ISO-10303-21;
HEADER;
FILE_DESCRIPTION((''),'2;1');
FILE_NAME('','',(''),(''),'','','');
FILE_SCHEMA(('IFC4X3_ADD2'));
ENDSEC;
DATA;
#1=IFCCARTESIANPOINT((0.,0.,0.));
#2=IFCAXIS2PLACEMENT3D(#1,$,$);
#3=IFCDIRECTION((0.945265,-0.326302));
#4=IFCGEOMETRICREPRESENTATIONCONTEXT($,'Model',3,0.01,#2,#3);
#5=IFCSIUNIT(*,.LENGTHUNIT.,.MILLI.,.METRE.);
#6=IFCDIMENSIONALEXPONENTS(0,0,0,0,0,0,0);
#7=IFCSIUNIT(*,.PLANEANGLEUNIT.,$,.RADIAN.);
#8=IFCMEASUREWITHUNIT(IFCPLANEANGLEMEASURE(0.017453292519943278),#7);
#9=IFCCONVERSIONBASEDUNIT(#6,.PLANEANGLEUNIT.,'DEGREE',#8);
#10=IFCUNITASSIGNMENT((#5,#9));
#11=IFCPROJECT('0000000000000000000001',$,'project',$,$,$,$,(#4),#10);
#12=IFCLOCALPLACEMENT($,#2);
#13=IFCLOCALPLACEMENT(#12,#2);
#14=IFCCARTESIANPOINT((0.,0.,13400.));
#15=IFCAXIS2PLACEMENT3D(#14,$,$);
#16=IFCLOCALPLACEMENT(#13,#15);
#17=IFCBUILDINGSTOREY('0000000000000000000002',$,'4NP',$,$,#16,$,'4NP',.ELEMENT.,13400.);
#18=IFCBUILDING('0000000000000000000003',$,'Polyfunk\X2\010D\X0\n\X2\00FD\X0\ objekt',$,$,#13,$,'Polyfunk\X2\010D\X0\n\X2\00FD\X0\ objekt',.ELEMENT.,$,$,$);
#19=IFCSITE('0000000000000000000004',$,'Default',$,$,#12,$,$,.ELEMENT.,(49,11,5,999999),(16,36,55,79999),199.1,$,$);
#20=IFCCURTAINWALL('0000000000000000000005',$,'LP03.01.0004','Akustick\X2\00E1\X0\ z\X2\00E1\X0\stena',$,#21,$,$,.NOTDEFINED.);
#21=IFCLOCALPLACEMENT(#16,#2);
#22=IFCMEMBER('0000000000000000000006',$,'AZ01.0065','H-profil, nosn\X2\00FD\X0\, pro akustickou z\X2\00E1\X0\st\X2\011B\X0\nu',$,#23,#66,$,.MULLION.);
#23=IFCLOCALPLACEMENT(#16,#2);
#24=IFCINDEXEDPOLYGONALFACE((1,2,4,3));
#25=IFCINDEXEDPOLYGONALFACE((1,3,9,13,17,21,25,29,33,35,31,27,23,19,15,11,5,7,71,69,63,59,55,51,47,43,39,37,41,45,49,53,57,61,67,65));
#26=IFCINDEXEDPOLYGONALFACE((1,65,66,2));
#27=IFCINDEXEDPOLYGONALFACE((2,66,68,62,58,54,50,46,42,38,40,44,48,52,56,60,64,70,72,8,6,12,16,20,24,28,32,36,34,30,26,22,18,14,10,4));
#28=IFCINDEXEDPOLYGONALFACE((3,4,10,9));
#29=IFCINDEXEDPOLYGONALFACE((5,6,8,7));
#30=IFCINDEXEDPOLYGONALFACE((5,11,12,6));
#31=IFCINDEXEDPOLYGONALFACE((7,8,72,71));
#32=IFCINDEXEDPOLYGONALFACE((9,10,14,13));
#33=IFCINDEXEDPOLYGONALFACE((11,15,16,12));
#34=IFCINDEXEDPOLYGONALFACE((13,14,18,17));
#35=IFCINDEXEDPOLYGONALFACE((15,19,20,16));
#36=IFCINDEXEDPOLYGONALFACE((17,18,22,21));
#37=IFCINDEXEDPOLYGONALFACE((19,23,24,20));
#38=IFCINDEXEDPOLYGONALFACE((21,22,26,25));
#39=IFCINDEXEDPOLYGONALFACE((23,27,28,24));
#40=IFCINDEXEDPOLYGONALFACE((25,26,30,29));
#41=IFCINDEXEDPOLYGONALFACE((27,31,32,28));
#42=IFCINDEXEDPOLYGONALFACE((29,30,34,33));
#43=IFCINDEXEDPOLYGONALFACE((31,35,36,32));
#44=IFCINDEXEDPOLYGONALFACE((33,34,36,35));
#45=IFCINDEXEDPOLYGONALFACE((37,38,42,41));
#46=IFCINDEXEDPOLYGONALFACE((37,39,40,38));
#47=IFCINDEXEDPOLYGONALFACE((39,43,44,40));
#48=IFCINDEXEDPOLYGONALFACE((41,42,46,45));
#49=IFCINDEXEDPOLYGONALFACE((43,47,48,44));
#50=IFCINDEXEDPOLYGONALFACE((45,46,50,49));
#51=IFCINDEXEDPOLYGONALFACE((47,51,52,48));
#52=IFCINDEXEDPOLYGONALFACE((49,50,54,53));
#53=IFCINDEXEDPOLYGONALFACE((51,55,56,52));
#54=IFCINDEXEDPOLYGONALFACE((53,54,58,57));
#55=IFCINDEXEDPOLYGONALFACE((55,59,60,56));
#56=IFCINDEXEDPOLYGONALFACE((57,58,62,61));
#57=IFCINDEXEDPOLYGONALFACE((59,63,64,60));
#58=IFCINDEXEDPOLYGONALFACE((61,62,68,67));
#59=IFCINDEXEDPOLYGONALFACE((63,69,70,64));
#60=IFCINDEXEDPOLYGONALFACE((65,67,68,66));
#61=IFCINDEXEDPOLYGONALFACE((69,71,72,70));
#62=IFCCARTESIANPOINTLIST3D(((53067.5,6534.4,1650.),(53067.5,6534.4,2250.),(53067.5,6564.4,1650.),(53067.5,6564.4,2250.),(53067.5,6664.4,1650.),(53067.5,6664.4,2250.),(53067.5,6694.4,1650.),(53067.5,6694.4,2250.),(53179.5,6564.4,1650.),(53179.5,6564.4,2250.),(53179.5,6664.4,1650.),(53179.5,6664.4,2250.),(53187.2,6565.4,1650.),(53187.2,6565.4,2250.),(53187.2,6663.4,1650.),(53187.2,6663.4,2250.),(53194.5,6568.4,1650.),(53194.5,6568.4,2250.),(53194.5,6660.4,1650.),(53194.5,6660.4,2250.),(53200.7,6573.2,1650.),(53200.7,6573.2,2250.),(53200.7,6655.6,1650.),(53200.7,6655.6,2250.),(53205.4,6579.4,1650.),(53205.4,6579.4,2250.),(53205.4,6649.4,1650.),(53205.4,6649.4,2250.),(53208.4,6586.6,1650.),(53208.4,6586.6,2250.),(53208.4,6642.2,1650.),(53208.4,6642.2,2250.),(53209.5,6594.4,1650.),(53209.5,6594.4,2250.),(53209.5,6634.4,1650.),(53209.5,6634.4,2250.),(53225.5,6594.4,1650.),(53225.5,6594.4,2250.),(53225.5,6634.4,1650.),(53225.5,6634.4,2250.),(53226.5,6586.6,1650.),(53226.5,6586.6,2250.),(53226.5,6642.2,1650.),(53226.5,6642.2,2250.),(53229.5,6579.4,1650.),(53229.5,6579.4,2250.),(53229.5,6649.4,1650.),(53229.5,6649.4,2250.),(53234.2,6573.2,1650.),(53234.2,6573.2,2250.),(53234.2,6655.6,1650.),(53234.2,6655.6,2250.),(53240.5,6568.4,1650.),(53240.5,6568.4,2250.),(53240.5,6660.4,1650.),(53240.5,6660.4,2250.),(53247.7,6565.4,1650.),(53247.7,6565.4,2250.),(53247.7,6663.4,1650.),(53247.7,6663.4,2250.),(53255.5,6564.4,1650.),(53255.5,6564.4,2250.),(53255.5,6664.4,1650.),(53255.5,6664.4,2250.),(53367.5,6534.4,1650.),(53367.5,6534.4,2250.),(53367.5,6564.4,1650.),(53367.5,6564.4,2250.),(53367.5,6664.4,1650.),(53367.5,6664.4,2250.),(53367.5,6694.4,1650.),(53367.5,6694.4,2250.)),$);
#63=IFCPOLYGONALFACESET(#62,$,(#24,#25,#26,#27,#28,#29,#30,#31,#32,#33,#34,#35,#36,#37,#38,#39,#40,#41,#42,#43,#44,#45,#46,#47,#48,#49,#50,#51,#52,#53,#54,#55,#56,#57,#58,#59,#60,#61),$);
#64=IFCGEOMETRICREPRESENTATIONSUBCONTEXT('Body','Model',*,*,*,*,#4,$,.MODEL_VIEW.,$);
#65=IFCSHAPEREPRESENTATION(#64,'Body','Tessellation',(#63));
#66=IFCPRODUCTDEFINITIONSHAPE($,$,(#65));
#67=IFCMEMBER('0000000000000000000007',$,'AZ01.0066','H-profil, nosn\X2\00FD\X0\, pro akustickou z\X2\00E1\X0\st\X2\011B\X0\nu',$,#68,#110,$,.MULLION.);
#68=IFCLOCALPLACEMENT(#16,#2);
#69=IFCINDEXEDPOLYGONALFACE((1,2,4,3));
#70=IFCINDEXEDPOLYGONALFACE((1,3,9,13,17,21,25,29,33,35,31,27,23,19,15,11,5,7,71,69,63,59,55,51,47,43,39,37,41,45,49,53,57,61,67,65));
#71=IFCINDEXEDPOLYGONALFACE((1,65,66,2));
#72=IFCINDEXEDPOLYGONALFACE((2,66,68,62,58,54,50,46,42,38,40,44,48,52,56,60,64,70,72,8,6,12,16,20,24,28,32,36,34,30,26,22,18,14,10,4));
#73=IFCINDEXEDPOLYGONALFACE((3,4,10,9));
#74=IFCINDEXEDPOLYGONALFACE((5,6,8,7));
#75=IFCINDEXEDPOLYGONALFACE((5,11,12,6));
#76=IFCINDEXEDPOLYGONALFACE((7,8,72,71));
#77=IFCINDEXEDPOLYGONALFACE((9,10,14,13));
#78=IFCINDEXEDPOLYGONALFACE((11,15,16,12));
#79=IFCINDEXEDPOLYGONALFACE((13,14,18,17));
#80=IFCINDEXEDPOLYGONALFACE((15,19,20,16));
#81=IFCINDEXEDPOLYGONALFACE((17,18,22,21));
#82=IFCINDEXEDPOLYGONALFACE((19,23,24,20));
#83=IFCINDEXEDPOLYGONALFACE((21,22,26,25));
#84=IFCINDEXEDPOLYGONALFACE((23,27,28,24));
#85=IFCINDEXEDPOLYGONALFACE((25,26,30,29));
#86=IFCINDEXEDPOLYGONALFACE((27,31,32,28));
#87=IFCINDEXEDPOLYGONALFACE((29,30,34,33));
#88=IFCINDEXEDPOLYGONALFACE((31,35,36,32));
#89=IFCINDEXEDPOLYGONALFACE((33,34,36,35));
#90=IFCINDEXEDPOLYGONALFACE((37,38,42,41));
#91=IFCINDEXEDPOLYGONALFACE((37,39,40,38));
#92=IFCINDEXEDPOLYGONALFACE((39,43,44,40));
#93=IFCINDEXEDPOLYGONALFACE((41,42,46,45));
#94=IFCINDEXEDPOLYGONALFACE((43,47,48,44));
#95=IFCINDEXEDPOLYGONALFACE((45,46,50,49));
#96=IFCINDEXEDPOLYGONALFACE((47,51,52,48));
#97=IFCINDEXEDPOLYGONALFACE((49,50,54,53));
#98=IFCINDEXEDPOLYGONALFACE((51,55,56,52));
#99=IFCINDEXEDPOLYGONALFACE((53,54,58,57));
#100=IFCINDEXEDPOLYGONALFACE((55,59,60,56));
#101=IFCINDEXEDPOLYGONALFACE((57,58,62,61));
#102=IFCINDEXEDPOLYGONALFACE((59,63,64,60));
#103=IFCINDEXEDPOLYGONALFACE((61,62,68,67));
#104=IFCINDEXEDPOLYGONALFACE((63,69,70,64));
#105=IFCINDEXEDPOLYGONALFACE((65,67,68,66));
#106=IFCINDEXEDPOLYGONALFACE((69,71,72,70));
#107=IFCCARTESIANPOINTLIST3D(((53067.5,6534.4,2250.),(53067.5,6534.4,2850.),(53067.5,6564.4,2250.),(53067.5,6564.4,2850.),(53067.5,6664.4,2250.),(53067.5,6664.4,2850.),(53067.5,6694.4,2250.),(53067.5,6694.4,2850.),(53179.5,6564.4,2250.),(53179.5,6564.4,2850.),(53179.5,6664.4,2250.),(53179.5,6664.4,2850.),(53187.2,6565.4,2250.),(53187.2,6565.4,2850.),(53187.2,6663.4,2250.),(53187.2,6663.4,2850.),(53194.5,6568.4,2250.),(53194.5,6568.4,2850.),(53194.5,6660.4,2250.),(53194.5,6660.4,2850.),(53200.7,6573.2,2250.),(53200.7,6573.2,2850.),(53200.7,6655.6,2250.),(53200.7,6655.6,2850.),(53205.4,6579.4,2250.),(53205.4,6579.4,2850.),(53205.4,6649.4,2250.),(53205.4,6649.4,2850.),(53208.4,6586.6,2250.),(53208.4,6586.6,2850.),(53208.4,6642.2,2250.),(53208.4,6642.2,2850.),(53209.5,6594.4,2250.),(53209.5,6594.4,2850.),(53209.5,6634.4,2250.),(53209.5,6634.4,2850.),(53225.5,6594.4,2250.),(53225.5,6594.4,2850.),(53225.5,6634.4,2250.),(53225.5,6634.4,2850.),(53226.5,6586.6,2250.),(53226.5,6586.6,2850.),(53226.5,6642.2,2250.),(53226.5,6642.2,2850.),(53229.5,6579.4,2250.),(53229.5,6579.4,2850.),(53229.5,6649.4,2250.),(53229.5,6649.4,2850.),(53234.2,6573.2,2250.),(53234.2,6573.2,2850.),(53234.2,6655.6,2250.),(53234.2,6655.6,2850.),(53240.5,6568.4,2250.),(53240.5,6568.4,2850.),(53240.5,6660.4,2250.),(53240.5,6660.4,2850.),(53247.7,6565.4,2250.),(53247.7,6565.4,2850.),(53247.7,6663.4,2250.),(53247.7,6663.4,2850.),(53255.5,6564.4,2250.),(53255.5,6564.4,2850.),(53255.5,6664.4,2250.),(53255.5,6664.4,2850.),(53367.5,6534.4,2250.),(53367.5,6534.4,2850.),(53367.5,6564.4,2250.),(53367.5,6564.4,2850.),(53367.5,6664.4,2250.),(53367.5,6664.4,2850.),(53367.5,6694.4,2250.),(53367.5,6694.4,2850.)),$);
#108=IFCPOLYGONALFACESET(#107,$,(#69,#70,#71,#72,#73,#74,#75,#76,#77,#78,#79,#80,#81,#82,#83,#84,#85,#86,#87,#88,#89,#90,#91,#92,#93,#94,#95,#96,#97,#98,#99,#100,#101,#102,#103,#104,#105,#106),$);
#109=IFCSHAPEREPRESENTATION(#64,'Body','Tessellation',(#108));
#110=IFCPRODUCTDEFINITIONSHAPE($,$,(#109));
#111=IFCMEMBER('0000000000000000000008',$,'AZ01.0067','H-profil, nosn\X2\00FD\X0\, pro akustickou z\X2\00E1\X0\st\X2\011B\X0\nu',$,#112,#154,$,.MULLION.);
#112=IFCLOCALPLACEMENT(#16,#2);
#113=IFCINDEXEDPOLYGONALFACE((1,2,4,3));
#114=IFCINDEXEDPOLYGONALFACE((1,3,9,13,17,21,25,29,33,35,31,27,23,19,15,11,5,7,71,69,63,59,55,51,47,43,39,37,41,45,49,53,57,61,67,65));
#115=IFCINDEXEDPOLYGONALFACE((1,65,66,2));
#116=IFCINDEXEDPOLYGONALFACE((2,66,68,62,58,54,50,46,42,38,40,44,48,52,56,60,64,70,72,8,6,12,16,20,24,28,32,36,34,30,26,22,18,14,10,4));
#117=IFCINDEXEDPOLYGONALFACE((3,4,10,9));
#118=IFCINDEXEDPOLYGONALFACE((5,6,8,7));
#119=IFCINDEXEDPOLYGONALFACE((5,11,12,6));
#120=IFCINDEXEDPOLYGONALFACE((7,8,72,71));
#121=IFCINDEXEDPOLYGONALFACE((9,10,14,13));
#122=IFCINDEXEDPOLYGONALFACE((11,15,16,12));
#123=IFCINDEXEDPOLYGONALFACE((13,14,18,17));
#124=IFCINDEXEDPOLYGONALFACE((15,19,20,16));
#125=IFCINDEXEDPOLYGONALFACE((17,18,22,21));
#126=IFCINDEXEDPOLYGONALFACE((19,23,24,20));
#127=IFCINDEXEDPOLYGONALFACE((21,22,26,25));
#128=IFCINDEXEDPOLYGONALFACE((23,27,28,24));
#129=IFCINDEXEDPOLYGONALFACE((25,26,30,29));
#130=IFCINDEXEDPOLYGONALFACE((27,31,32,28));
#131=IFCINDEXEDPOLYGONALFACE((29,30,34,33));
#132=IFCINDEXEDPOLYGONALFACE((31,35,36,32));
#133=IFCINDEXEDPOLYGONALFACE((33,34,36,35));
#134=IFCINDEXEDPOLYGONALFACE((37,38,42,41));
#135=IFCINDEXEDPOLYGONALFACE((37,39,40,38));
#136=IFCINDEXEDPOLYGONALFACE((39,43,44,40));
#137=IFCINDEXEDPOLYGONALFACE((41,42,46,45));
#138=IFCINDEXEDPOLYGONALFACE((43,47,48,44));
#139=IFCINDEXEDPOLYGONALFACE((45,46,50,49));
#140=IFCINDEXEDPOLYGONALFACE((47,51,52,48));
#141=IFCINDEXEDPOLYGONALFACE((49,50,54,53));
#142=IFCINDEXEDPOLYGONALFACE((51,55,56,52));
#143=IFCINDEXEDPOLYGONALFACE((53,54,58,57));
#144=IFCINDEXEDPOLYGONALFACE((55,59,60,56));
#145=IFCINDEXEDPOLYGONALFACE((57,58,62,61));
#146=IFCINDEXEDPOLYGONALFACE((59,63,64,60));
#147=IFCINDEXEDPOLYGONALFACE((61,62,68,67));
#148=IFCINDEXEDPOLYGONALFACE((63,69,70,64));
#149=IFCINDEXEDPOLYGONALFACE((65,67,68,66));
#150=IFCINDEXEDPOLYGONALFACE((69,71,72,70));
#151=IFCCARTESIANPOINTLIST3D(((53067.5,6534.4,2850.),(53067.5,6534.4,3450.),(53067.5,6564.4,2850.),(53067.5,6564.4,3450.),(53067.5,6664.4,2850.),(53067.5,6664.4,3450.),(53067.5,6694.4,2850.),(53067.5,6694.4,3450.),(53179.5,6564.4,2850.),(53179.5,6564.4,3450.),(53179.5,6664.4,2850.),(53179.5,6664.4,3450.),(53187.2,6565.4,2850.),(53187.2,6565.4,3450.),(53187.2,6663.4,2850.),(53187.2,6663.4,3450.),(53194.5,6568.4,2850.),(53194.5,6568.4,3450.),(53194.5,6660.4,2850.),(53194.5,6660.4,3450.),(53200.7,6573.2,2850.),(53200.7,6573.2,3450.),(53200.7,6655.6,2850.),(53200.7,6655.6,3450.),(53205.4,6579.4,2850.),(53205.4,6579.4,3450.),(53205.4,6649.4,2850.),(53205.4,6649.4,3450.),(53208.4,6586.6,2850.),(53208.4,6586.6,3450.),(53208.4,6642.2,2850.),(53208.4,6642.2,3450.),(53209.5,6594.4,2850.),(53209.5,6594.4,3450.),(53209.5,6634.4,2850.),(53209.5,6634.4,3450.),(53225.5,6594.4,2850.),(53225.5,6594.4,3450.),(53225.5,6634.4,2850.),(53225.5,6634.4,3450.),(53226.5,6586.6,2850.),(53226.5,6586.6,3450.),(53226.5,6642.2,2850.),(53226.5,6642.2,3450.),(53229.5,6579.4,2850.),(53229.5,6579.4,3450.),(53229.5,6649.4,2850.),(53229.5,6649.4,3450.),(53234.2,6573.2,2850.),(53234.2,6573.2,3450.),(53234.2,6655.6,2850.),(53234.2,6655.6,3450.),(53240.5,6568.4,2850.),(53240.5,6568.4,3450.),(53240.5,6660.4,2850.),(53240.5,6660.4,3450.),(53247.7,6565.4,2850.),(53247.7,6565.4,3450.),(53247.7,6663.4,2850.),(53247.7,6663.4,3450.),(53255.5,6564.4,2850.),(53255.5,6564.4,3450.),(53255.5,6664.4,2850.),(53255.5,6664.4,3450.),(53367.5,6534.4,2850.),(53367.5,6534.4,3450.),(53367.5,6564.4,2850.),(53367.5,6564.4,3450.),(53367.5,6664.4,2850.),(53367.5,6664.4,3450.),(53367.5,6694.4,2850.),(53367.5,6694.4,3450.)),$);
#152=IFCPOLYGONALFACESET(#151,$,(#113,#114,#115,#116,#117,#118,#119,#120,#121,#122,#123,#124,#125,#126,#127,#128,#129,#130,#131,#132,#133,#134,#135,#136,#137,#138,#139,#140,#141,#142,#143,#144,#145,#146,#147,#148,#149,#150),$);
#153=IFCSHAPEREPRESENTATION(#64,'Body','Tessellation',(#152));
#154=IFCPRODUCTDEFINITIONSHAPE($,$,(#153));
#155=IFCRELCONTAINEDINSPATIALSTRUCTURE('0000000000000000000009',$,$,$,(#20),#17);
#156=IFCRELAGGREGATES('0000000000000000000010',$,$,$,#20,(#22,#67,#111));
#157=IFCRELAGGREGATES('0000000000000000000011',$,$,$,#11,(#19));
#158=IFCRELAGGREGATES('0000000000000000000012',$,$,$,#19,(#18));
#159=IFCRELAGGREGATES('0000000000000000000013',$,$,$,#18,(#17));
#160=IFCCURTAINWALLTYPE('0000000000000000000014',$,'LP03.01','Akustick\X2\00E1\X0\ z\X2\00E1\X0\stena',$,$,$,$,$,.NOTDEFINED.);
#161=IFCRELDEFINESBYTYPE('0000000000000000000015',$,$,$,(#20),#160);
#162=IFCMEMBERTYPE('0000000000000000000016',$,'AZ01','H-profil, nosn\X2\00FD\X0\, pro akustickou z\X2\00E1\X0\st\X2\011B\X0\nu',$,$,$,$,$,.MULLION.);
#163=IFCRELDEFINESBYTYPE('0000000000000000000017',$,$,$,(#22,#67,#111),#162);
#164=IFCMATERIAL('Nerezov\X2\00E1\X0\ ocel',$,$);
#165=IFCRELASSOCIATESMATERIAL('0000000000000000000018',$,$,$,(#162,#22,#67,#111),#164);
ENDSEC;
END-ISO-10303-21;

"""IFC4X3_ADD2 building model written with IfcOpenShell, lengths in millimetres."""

from ifc_helpers import new_model, entity, si_unit, converted_unit, direction, frame, frame_2d, origin, place, context, subcontext, project, spatial, polyline, circle_curve, parameter, trimmed, segment, composite_curve, outline, extrude, source, transform, mapped, material, material_profile, profile_set, profile_usage, type_object, element, aggregate, save


model = new_model("IFC4X3_ADD2")

# Units and contexts
model_context = context("Model", 3, precision=0.01, world=origin(), true_north=direction((0.945265, -0.326302)))
body_context = subcontext(model_context, "Body", "Model", "MODEL_VIEW")
ifc_project = project(units=[si_unit("LENGTHUNIT", "METRE", prefix="MILLI"), converted_unit("PLANEANGLEUNIT", "DEGREE", entity("IfcPlaneAngleMeasure", 0.017453292519943278), si_unit("PLANEANGLEUNIT", "RADIAN"), dimensions=[0, 0, 0, 0, 0, 0, 0])], contexts=[model_context])

# Site, building, storey
site_placement = place(None, origin())
site = spatial("IfcSite", under=ifc_project, at=site_placement, Name="Default", CompositionType="ELEMENT", RefLatitude=(49, 11, 5, 999999), RefLongitude=(16, 36, 55, 79999), RefElevation=199.1)
building_placement = place(site_placement, origin())
building = spatial("IfcBuilding", under=site, at=building_placement, Name="Polyfunkčný objekt", LongName="Polyfunkčný objekt", CompositionType="ELEMENT")
storey_placement = place(building_placement, frame((0.0, 0.0, 13400.0)))
storey = spatial("IfcBuildingStorey", under=building, at=storey_placement, Name="4NP", LongName="4NP", CompositionType="ELEMENT", Elevation=13400.0)

# Curtain wall, members
curtain_wall_type = type_object("IfcCurtainWallType", Name="LP03.01", Description="Akustická zástena", PredefinedType="NOTDEFINED")
curtain_wall_placement = place(storey_placement, frame((0.0, 0.0, -13400.0)))
curtain_wall = element("IfcCurtainWall", 1, at=curtain_wall_placement, inside=storey, type_object=curtain_wall_type, Name="LP03.01.0004", Description="Akustická zástena", PredefinedType="NOTDEFINED")
ifc_material_1 = material(Name="Nerezová ocel")
ifc_material_profile = material_profile(ifc_material_1, outline(composite_curve([segment(polyline([(50.0, -150.0), (80.0, -150.0)]), True, "CONTINUOUS"), segment(polyline([(80.0, -150.0), (80.0, 150.0)]), True, "CONTINUOUS"), segment(polyline([(80.0, 150.0), (50.0, 150.0)]), True, "CONTINUOUS"), segment(polyline([(50.0, 150.0), (50.0, 38.0)]), True, "CONTINUOUS"), segment(trimmed(circle_curve(frame_2d((20.0, 38.0), x_axis=(0.0, 1.0)), 30.0), [parameter(180.0)], [parameter(270.0)], True, "PARAMETER"), False, "CONTINUOUS"), segment(polyline([(20.0, 8.0), (-20.0, 8.0)]), True, "CONTINUOUS"), segment(trimmed(circle_curve(frame_2d((-20.0, 38.0), x_axis=(0.0, 1.0)), 30.0), [parameter(90.0)], [parameter(180.0)], True, "PARAMETER"), False, "CONTINUOUS"), segment(polyline([(-50.0, 38.0), (-50.0, 150.0)]), True, "CONTINUOUS"), segment(polyline([(-50.0, 150.0), (-80.0, 150.0)]), True, "CONTINUOUS"), segment(polyline([(-80.0, 150.0), (-80.0, -150.0)]), True, "CONTINUOUS"), segment(polyline([(-80.0, -150.0), (-50.0, -150.0)]), True, "CONTINUOUS"), segment(polyline([(-50.0, -150.0), (-50.0, -38.0)]), True, "CONTINUOUS"), segment(trimmed(circle_curve(frame_2d((-20.0, -38.0), x_axis=(0.0, 1.0)), 30.0), [parameter(0.0)], [parameter(90.0)], True, "PARAMETER"), False, "CONTINUOUS"), segment(polyline([(-20.0, -8.0), (20.0, -8.0)]), True, "CONTINUOUS"), segment(trimmed(circle_curve(frame_2d((20.0, -38.0), x_axis=(0.0, 1.0)), 30.0), [parameter(270.0)], [parameter(0.0)], True, "PARAMETER"), False, "CONTINUOUS"), segment(polyline([(50.0, -38.0), (50.0, -150.0)]), True, "CONTINUOUS")], self_intersect=False)), Name="Profil zástena")
ifc_profile_set = profile_set([ifc_material_profile], Name="Profil zástena")
ifc_profile_usage = profile_usage(ifc_profile_set)
member_type = type_object("IfcMemberType", Name="AZ01", Description="H-profil, nosný, pro akustickou zástěnu", PredefinedType="MULLION", material=ifc_profile_set)
shared_shape_1 = source(origin(), body_context, "Body", "SweptSolid", [
    extrude(outline(composite_curve([segment(polyline([(50.0, -150.0), (80.0, -150.0)]), True, "CONTINUOUS"), segment(polyline([(80.0, -150.0), (80.0, 150.0)]), True, "CONTINUOUS"), segment(polyline([(80.0, 150.0), (50.0, 150.0)]), True, "CONTINUOUS"), segment(polyline([(50.0, 150.0), (50.0, 38.0)]), True, "CONTINUOUS"), segment(trimmed(circle_curve(frame_2d((20.0, 38.0), x_axis=(0.0, 1.0)), 30.0), [parameter(180.0)], [parameter(270.0)], True, "PARAMETER"), False, "CONTINUOUS"), segment(polyline([(20.0, 8.0), (-20.0, 8.0)]), True, "CONTINUOUS"), segment(trimmed(circle_curve(frame_2d((-20.0, 38.0), x_axis=(0.0, 1.0)), 30.0), [parameter(90.0)], [parameter(180.0)], True, "PARAMETER"), False, "CONTINUOUS"), segment(polyline([(-50.0, 38.0), (-50.0, 150.0)]), True, "CONTINUOUS"), segment(polyline([(-50.0, 150.0), (-80.0, 150.0)]), True, "CONTINUOUS"), segment(polyline([(-80.0, 150.0), (-80.0, -150.0)]), True, "CONTINUOUS"), segment(polyline([(-80.0, -150.0), (-50.0, -150.0)]), True, "CONTINUOUS"), segment(polyline([(-50.0, -150.0), (-50.0, -38.0)]), True, "CONTINUOUS"), segment(trimmed(circle_curve(frame_2d((-20.0, -38.0), x_axis=(0.0, 1.0)), 30.0), [parameter(0.0)], [parameter(90.0)], True, "PARAMETER"), False, "CONTINUOUS"), segment(polyline([(-20.0, -8.0), (20.0, -8.0)]), True, "CONTINUOUS"), segment(trimmed(circle_curve(frame_2d((20.0, -38.0), x_axis=(0.0, 1.0)), 30.0), [parameter(270.0)], [parameter(0.0)], True, "PARAMETER"), False, "CONTINUOUS"), segment(polyline([(50.0, -38.0), (50.0, -150.0)]), True, "CONTINUOUS")], self_intersect=False)), frame((0.0, 0.0, -600.0), z_axis=(0.0, 0.0, 1.0), x_axis=(0.0, -1.0, 0.0)), (0.0, 0.0, 1.0), 600.0),
])
member_1_placement = place(curtain_wall_placement, frame((53217.5, 6614.4, 15050.0), z_axis=(0.0, 0.0, -1.0), x_axis=(1.0, 0.0, 0.0)))
member_1 = element("IfcMember", 2, at=member_1_placement, type_object=member_type, material=ifc_profile_usage, Name="AZ01.0065", Description="H-profil, nosný, pro akustickou zástěnu", PredefinedType="MULLION", context=body_context, shape_type="MappedRepresentation", body=[
    mapped(shared_shape_1, transform((0.0, 0.0, 0.0), scale=1.0)),
])
member_2_placement = place(curtain_wall_placement, frame((53217.5, 6614.4, 15650.0), z_axis=(0.0, 0.0, -1.0), x_axis=(1.0, 0.0, 0.0)))
member_2 = element("IfcMember", 3, at=member_2_placement, type_object=member_type, material=ifc_profile_usage, Name="AZ01.0066", Description="H-profil, nosný, pro akustickou zástěnu", PredefinedType="MULLION", context=body_context, shape_type="MappedRepresentation", body=[
    mapped(shared_shape_1, transform((0.0, 0.0, 0.0), scale=1.0)),
])
member_3_placement = place(curtain_wall_placement, frame((53217.5, 6614.4, 16250.0), z_axis=(0.0, 0.0, -1.0), x_axis=(1.0, 0.0, 0.0)))
member_3 = element("IfcMember", 4, at=member_3_placement, type_object=member_type, material=ifc_profile_usage, Name="AZ01.0067", Description="H-profil, nosný, pro akustickou zástěnu", PredefinedType="MULLION", context=body_context, shape_type="MappedRepresentation", body=[
    mapped(shared_shape_1, transform((0.0, 0.0, 0.0), scale=1.0)),
])
aggregate(curtain_wall, [member_1, member_2, member_3])

save(model, "model.ifc")
